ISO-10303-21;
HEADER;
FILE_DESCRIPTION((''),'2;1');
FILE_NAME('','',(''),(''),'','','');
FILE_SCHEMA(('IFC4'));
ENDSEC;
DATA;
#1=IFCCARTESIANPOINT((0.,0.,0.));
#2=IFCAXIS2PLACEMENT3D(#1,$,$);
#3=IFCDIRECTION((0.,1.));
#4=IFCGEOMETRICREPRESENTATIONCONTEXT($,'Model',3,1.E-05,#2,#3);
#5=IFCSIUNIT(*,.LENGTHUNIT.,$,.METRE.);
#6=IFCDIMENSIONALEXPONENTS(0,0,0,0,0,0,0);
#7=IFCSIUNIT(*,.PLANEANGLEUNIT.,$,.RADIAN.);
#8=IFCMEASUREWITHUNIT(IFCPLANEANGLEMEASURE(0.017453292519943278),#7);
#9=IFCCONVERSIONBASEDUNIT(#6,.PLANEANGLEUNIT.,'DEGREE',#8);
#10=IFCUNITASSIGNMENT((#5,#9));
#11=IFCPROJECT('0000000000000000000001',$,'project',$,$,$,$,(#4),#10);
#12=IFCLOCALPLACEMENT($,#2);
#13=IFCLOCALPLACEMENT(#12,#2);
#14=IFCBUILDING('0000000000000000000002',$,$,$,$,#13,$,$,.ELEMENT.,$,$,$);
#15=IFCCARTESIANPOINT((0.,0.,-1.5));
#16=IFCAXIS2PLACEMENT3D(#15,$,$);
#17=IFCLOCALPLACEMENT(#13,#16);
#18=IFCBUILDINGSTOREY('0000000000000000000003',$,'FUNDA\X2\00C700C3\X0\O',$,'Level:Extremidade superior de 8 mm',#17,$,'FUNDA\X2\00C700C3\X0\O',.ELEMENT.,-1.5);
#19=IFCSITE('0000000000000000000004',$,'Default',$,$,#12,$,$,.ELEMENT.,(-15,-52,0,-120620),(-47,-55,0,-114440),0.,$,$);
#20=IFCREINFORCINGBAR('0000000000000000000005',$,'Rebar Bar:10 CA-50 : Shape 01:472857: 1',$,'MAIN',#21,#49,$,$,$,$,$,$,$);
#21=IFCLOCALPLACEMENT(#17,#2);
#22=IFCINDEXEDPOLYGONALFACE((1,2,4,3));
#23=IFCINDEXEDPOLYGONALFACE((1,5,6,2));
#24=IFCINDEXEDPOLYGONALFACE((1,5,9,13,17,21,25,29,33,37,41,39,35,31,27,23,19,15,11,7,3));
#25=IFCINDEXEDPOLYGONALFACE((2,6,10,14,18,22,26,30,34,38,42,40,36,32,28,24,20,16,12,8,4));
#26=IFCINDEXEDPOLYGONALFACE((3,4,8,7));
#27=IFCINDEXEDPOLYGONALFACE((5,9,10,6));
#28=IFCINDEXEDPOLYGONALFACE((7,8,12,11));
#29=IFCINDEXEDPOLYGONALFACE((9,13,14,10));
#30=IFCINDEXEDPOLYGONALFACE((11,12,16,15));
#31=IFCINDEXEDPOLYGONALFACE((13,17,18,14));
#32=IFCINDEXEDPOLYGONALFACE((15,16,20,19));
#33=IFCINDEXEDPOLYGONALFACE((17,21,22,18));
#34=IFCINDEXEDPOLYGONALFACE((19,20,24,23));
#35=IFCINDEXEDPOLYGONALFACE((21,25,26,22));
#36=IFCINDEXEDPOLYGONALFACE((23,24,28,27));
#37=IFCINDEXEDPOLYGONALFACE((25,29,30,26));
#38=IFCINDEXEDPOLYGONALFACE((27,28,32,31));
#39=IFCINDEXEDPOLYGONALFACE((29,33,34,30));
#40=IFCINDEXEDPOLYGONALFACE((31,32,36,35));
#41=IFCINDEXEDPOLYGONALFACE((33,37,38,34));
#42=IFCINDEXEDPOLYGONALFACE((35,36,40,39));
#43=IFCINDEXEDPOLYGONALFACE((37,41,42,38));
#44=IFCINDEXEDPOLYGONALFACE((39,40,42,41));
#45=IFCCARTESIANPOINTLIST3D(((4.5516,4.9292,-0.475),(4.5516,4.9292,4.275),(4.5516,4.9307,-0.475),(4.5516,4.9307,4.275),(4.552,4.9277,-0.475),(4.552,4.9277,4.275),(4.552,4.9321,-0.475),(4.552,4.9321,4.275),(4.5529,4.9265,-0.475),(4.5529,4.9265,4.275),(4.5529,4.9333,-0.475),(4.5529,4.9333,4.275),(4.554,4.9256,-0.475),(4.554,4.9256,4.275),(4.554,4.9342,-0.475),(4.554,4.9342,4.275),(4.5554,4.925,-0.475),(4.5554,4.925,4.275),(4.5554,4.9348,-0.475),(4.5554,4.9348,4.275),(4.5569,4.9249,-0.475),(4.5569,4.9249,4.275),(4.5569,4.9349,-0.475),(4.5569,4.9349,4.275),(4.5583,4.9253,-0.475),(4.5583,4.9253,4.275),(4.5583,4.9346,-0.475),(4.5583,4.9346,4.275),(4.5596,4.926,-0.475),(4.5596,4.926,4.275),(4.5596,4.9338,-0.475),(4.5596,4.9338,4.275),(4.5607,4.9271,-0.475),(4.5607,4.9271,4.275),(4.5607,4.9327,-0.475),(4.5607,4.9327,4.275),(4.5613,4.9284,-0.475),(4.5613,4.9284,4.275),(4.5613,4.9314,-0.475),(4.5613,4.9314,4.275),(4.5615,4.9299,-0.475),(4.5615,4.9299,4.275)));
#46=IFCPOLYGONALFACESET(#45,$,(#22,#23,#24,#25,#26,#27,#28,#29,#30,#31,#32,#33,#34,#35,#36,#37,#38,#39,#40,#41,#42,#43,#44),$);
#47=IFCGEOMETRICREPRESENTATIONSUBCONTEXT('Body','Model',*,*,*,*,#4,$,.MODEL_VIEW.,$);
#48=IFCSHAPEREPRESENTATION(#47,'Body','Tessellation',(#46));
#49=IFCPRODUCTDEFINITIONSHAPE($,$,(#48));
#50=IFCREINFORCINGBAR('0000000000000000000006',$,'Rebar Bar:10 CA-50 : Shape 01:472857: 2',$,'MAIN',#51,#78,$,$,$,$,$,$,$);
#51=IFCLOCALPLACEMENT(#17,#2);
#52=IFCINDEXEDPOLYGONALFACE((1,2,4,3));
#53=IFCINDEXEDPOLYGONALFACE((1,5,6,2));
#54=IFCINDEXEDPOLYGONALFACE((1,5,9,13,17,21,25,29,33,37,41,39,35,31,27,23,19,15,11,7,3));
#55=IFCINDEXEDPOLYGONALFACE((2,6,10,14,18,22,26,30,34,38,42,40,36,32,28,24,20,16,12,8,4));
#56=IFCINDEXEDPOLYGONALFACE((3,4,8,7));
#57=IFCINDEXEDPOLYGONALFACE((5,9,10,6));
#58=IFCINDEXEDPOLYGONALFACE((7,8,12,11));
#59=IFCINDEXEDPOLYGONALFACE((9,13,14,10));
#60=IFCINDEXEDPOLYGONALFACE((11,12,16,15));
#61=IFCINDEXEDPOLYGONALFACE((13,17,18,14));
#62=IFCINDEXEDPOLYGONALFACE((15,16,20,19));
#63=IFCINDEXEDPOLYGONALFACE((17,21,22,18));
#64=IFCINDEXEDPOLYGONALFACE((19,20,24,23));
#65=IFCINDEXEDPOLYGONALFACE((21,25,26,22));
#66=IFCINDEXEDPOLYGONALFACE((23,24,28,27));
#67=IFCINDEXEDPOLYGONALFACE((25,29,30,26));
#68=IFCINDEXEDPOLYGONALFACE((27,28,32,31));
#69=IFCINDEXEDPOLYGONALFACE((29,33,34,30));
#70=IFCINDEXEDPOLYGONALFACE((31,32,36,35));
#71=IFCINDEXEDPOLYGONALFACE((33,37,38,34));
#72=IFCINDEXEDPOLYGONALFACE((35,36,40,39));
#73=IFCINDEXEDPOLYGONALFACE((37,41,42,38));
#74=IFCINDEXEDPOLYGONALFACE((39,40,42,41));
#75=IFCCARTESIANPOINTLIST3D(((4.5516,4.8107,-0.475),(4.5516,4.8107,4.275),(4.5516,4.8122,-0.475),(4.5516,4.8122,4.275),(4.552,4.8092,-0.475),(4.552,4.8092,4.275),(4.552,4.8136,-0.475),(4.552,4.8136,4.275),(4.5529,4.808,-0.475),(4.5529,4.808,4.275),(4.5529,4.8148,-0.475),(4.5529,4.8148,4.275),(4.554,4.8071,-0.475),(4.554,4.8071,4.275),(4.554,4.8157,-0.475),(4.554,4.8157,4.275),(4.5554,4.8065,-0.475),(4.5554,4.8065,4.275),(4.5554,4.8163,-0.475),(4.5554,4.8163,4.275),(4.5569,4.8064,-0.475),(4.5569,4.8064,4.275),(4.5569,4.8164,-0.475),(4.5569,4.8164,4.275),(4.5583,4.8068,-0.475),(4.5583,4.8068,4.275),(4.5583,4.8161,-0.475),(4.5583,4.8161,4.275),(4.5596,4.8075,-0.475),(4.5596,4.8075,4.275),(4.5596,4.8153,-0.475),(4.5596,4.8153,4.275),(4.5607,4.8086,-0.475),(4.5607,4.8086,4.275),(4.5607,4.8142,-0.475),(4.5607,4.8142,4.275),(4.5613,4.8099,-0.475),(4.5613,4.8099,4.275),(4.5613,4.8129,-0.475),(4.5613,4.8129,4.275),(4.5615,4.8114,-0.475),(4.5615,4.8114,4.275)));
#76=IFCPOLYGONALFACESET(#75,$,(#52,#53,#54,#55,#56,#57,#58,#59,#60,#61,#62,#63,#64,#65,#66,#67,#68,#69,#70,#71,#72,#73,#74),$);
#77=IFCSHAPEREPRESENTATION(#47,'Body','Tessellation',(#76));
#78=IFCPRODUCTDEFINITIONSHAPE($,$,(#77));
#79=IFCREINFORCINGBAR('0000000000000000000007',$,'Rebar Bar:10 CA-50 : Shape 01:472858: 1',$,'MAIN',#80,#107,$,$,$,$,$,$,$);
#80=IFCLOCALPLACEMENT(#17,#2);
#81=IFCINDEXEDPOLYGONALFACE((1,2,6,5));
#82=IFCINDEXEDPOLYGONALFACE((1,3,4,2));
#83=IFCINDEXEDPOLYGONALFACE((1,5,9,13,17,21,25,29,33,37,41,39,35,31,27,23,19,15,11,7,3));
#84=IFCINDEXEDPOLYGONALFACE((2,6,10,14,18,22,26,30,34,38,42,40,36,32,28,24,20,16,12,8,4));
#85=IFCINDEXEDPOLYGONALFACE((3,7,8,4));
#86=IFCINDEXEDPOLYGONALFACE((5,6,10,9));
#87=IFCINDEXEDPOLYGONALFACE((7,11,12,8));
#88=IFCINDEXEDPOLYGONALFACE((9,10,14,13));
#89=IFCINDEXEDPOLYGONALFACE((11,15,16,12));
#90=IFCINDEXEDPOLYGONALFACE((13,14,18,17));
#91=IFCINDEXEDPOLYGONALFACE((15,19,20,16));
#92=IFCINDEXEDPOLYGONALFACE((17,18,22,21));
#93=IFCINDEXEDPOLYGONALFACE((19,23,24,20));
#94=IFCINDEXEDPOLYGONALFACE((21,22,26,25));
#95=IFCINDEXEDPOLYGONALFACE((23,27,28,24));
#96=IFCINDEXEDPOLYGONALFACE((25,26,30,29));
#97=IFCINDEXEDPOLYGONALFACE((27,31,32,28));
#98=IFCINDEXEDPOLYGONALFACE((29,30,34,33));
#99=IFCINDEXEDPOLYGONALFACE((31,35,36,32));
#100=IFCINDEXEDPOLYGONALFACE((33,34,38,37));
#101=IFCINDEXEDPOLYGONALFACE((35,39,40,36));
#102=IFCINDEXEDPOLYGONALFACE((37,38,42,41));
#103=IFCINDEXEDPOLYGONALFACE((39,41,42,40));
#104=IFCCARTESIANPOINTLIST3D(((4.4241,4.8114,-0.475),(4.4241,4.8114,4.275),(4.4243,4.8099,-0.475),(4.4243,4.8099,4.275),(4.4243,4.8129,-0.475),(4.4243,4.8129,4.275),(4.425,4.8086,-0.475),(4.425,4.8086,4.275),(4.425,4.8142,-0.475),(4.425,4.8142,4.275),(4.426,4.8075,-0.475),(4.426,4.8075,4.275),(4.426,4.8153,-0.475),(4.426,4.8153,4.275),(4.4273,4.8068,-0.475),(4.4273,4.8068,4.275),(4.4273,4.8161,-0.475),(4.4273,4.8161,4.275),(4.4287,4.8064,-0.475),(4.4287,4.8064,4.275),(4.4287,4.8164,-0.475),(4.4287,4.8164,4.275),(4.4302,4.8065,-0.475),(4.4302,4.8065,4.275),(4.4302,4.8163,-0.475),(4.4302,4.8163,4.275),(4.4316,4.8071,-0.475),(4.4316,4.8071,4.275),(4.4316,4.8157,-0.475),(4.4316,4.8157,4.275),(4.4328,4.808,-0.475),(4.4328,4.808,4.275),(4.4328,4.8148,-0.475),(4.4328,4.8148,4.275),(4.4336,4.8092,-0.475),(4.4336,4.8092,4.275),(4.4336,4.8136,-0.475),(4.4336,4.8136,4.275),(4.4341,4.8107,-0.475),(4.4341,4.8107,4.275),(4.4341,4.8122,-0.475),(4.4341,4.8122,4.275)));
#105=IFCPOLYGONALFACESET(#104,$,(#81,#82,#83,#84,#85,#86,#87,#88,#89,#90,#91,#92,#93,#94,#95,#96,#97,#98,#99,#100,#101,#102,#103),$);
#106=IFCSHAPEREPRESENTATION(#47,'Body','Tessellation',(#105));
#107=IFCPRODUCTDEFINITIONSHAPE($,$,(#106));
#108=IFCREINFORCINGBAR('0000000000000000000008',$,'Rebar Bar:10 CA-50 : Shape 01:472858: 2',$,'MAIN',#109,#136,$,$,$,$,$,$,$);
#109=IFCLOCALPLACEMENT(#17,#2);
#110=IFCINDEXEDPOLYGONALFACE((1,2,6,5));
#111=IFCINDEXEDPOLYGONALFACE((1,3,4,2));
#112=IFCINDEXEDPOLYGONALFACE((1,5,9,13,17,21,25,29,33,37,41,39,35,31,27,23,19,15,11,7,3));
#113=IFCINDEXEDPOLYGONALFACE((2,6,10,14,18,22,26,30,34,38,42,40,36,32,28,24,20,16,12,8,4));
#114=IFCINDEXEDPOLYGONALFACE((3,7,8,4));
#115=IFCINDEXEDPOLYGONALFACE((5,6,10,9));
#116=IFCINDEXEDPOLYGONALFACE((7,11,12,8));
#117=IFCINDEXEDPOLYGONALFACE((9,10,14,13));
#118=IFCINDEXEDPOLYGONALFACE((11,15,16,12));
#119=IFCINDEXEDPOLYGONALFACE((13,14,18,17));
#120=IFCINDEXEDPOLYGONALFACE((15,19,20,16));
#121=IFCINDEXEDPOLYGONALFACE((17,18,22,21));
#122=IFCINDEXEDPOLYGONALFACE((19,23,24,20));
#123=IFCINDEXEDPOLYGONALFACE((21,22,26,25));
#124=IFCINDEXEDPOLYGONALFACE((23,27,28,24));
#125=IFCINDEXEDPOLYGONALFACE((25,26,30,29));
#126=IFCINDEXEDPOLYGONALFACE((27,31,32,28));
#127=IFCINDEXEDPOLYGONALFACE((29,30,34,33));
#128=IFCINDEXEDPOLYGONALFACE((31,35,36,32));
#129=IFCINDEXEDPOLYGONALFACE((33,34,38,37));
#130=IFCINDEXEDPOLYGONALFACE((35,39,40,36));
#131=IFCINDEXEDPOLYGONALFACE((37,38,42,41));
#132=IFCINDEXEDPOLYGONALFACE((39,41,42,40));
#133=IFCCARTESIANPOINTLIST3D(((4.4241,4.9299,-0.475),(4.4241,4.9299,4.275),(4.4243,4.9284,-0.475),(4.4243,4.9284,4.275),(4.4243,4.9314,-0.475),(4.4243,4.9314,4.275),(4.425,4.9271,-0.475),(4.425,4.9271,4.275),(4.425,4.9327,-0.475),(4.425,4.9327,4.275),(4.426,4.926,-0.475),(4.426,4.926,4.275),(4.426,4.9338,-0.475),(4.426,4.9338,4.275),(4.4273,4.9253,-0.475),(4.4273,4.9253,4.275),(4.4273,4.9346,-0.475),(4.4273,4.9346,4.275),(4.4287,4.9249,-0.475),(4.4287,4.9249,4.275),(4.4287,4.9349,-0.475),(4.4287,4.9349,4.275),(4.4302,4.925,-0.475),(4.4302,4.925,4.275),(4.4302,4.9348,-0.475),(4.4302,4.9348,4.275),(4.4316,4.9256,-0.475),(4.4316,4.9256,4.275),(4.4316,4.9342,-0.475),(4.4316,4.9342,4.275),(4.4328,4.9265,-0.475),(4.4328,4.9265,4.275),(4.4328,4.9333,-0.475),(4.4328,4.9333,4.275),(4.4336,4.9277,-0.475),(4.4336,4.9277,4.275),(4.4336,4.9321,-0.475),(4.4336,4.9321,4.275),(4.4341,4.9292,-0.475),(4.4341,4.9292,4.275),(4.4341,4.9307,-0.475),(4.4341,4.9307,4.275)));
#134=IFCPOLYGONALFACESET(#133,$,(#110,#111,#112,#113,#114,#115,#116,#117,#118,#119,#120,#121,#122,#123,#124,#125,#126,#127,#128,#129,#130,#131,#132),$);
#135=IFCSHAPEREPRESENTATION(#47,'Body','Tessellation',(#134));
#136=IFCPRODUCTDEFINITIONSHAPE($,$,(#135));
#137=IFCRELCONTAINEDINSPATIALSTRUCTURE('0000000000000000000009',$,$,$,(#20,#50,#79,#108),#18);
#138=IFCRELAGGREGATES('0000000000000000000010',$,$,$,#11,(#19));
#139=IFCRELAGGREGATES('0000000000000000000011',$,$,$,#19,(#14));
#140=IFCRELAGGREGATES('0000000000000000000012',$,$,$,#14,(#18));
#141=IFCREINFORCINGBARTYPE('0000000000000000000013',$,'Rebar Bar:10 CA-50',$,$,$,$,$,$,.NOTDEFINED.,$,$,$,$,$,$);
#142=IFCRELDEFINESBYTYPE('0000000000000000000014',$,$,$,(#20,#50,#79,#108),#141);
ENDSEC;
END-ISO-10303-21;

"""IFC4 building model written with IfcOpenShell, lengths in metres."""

from ifc_helpers import new_model, entity, si_unit, converted_unit, direction, frame, origin, place, context, subcontext, project, spatial, type_object, element, save


model = new_model("IFC4")

# Units and contexts
model_context = context("Model", 3, precision=1e-05, world=origin(), true_north=direction((0.0, 1.0)))
body_context = subcontext(model_context, "Body", "Model", "MODEL_VIEW")
ifc_project = project(units=[si_unit("LENGTHUNIT", "METRE"), converted_unit("PLANEANGLEUNIT", "DEGREE", entity("IfcPlaneAngleMeasure", 0.017453292519943278), si_unit("PLANEANGLEUNIT", "RADIAN"), dimensions=[0, 0, 0, 0, 0, 0, 0])], contexts=[model_context])

# Site, building, storey
site_placement = place(None, origin())
site = spatial("IfcSite", under=ifc_project, at=site_placement, Name="Default", CompositionType="ELEMENT", RefLatitude=(-15, -52, 0, -120620), RefLongitude=(-47, -55, 0, -114440), RefElevation=0.0)
building_placement = place(site_placement, origin())
building = spatial("IfcBuilding", under=site, at=building_placement, CompositionType="ELEMENT")
storey_placement = place(building_placement, frame((0.0, 0.0, -1.5)))
storey = spatial("IfcBuildingStorey", under=building, at=storey_placement, Name="FUNDAÇÃO", ObjectType="Level:Extremidade superior de 8 mm", LongName="FUNDAÇÃO", CompositionType="ELEMENT", Elevation=-1.5)

# Reinforcing bars
reinforcing_bar_type_1 = type_object("IfcReinforcingBarType", Name="Rebar Bar:10 CA-50", PredefinedType="NOTDEFINED")
reinforcing_bar_1_placement = place(storey_placement, origin())
element("IfcReinforcingBar", 1, at=reinforcing_bar_1_placement, inside=storey, type_object=reinforcing_bar_type_1, Name="Rebar Bar:10 CA-50 : Shape 01:472857: 1", ObjectType="MAIN", context=body_context, shape_type="AdvancedSweptSolid", body=[
    entity("IfcSweptDiskSolid", entity("IfcIndexedPolyCurve", entity("IfcCartesianPointList3D", [[4.5565, 4.9299, -0.475], [4.5565, 4.9299, 4.275]]), None, False), 0.005, None, 0.0, 1.0),
])
reinforcing_bar_2_placement = place(storey_placement, origin())
element("IfcReinforcingBar", 2, at=reinforcing_bar_2_placement, inside=storey, type_object=reinforcing_bar_type_1, Name="Rebar Bar:10 CA-50 : Shape 01:472857: 2", ObjectType="MAIN", context=body_context, shape_type="AdvancedSweptSolid", body=[
    entity("IfcSweptDiskSolid", entity("IfcIndexedPolyCurve", entity("IfcCartesianPointList3D", [[4.5565, 4.8114, -0.475], [4.5565, 4.8114, 4.275]]), None, False), 0.005, None, 0.0, 1.0),
])
reinforcing_bar_3_placement = place(storey_placement, origin())
element("IfcReinforcingBar", 3, at=reinforcing_bar_3_placement, inside=storey, type_object=reinforcing_bar_type_1, Name="Rebar Bar:10 CA-50 : Shape 01:472858: 1", ObjectType="MAIN", context=body_context, shape_type="AdvancedSweptSolid", body=[
    entity("IfcSweptDiskSolid", entity("IfcIndexedPolyCurve", entity("IfcCartesianPointList3D", [[4.4291, 4.8114, 4.275], [4.4291, 4.8114, -0.475]]), None, False), 0.005, None, 0.0, 1.0),
])
reinforcing_bar_4_placement = place(storey_placement, origin())
element("IfcReinforcingBar", 4, at=reinforcing_bar_4_placement, inside=storey, type_object=reinforcing_bar_type_1, Name="Rebar Bar:10 CA-50 : Shape 01:472858: 2", ObjectType="MAIN", context=body_context, shape_type="AdvancedSweptSolid", body=[
    entity("IfcSweptDiskSolid", entity("IfcIndexedPolyCurve", entity("IfcCartesianPointList3D", [[4.4291, 4.9299, 4.275], [4.4291, 4.9299, -0.475]]), None, False), 0.005, None, 0.0, 1.0),
])

save(model, "model.ifc")
